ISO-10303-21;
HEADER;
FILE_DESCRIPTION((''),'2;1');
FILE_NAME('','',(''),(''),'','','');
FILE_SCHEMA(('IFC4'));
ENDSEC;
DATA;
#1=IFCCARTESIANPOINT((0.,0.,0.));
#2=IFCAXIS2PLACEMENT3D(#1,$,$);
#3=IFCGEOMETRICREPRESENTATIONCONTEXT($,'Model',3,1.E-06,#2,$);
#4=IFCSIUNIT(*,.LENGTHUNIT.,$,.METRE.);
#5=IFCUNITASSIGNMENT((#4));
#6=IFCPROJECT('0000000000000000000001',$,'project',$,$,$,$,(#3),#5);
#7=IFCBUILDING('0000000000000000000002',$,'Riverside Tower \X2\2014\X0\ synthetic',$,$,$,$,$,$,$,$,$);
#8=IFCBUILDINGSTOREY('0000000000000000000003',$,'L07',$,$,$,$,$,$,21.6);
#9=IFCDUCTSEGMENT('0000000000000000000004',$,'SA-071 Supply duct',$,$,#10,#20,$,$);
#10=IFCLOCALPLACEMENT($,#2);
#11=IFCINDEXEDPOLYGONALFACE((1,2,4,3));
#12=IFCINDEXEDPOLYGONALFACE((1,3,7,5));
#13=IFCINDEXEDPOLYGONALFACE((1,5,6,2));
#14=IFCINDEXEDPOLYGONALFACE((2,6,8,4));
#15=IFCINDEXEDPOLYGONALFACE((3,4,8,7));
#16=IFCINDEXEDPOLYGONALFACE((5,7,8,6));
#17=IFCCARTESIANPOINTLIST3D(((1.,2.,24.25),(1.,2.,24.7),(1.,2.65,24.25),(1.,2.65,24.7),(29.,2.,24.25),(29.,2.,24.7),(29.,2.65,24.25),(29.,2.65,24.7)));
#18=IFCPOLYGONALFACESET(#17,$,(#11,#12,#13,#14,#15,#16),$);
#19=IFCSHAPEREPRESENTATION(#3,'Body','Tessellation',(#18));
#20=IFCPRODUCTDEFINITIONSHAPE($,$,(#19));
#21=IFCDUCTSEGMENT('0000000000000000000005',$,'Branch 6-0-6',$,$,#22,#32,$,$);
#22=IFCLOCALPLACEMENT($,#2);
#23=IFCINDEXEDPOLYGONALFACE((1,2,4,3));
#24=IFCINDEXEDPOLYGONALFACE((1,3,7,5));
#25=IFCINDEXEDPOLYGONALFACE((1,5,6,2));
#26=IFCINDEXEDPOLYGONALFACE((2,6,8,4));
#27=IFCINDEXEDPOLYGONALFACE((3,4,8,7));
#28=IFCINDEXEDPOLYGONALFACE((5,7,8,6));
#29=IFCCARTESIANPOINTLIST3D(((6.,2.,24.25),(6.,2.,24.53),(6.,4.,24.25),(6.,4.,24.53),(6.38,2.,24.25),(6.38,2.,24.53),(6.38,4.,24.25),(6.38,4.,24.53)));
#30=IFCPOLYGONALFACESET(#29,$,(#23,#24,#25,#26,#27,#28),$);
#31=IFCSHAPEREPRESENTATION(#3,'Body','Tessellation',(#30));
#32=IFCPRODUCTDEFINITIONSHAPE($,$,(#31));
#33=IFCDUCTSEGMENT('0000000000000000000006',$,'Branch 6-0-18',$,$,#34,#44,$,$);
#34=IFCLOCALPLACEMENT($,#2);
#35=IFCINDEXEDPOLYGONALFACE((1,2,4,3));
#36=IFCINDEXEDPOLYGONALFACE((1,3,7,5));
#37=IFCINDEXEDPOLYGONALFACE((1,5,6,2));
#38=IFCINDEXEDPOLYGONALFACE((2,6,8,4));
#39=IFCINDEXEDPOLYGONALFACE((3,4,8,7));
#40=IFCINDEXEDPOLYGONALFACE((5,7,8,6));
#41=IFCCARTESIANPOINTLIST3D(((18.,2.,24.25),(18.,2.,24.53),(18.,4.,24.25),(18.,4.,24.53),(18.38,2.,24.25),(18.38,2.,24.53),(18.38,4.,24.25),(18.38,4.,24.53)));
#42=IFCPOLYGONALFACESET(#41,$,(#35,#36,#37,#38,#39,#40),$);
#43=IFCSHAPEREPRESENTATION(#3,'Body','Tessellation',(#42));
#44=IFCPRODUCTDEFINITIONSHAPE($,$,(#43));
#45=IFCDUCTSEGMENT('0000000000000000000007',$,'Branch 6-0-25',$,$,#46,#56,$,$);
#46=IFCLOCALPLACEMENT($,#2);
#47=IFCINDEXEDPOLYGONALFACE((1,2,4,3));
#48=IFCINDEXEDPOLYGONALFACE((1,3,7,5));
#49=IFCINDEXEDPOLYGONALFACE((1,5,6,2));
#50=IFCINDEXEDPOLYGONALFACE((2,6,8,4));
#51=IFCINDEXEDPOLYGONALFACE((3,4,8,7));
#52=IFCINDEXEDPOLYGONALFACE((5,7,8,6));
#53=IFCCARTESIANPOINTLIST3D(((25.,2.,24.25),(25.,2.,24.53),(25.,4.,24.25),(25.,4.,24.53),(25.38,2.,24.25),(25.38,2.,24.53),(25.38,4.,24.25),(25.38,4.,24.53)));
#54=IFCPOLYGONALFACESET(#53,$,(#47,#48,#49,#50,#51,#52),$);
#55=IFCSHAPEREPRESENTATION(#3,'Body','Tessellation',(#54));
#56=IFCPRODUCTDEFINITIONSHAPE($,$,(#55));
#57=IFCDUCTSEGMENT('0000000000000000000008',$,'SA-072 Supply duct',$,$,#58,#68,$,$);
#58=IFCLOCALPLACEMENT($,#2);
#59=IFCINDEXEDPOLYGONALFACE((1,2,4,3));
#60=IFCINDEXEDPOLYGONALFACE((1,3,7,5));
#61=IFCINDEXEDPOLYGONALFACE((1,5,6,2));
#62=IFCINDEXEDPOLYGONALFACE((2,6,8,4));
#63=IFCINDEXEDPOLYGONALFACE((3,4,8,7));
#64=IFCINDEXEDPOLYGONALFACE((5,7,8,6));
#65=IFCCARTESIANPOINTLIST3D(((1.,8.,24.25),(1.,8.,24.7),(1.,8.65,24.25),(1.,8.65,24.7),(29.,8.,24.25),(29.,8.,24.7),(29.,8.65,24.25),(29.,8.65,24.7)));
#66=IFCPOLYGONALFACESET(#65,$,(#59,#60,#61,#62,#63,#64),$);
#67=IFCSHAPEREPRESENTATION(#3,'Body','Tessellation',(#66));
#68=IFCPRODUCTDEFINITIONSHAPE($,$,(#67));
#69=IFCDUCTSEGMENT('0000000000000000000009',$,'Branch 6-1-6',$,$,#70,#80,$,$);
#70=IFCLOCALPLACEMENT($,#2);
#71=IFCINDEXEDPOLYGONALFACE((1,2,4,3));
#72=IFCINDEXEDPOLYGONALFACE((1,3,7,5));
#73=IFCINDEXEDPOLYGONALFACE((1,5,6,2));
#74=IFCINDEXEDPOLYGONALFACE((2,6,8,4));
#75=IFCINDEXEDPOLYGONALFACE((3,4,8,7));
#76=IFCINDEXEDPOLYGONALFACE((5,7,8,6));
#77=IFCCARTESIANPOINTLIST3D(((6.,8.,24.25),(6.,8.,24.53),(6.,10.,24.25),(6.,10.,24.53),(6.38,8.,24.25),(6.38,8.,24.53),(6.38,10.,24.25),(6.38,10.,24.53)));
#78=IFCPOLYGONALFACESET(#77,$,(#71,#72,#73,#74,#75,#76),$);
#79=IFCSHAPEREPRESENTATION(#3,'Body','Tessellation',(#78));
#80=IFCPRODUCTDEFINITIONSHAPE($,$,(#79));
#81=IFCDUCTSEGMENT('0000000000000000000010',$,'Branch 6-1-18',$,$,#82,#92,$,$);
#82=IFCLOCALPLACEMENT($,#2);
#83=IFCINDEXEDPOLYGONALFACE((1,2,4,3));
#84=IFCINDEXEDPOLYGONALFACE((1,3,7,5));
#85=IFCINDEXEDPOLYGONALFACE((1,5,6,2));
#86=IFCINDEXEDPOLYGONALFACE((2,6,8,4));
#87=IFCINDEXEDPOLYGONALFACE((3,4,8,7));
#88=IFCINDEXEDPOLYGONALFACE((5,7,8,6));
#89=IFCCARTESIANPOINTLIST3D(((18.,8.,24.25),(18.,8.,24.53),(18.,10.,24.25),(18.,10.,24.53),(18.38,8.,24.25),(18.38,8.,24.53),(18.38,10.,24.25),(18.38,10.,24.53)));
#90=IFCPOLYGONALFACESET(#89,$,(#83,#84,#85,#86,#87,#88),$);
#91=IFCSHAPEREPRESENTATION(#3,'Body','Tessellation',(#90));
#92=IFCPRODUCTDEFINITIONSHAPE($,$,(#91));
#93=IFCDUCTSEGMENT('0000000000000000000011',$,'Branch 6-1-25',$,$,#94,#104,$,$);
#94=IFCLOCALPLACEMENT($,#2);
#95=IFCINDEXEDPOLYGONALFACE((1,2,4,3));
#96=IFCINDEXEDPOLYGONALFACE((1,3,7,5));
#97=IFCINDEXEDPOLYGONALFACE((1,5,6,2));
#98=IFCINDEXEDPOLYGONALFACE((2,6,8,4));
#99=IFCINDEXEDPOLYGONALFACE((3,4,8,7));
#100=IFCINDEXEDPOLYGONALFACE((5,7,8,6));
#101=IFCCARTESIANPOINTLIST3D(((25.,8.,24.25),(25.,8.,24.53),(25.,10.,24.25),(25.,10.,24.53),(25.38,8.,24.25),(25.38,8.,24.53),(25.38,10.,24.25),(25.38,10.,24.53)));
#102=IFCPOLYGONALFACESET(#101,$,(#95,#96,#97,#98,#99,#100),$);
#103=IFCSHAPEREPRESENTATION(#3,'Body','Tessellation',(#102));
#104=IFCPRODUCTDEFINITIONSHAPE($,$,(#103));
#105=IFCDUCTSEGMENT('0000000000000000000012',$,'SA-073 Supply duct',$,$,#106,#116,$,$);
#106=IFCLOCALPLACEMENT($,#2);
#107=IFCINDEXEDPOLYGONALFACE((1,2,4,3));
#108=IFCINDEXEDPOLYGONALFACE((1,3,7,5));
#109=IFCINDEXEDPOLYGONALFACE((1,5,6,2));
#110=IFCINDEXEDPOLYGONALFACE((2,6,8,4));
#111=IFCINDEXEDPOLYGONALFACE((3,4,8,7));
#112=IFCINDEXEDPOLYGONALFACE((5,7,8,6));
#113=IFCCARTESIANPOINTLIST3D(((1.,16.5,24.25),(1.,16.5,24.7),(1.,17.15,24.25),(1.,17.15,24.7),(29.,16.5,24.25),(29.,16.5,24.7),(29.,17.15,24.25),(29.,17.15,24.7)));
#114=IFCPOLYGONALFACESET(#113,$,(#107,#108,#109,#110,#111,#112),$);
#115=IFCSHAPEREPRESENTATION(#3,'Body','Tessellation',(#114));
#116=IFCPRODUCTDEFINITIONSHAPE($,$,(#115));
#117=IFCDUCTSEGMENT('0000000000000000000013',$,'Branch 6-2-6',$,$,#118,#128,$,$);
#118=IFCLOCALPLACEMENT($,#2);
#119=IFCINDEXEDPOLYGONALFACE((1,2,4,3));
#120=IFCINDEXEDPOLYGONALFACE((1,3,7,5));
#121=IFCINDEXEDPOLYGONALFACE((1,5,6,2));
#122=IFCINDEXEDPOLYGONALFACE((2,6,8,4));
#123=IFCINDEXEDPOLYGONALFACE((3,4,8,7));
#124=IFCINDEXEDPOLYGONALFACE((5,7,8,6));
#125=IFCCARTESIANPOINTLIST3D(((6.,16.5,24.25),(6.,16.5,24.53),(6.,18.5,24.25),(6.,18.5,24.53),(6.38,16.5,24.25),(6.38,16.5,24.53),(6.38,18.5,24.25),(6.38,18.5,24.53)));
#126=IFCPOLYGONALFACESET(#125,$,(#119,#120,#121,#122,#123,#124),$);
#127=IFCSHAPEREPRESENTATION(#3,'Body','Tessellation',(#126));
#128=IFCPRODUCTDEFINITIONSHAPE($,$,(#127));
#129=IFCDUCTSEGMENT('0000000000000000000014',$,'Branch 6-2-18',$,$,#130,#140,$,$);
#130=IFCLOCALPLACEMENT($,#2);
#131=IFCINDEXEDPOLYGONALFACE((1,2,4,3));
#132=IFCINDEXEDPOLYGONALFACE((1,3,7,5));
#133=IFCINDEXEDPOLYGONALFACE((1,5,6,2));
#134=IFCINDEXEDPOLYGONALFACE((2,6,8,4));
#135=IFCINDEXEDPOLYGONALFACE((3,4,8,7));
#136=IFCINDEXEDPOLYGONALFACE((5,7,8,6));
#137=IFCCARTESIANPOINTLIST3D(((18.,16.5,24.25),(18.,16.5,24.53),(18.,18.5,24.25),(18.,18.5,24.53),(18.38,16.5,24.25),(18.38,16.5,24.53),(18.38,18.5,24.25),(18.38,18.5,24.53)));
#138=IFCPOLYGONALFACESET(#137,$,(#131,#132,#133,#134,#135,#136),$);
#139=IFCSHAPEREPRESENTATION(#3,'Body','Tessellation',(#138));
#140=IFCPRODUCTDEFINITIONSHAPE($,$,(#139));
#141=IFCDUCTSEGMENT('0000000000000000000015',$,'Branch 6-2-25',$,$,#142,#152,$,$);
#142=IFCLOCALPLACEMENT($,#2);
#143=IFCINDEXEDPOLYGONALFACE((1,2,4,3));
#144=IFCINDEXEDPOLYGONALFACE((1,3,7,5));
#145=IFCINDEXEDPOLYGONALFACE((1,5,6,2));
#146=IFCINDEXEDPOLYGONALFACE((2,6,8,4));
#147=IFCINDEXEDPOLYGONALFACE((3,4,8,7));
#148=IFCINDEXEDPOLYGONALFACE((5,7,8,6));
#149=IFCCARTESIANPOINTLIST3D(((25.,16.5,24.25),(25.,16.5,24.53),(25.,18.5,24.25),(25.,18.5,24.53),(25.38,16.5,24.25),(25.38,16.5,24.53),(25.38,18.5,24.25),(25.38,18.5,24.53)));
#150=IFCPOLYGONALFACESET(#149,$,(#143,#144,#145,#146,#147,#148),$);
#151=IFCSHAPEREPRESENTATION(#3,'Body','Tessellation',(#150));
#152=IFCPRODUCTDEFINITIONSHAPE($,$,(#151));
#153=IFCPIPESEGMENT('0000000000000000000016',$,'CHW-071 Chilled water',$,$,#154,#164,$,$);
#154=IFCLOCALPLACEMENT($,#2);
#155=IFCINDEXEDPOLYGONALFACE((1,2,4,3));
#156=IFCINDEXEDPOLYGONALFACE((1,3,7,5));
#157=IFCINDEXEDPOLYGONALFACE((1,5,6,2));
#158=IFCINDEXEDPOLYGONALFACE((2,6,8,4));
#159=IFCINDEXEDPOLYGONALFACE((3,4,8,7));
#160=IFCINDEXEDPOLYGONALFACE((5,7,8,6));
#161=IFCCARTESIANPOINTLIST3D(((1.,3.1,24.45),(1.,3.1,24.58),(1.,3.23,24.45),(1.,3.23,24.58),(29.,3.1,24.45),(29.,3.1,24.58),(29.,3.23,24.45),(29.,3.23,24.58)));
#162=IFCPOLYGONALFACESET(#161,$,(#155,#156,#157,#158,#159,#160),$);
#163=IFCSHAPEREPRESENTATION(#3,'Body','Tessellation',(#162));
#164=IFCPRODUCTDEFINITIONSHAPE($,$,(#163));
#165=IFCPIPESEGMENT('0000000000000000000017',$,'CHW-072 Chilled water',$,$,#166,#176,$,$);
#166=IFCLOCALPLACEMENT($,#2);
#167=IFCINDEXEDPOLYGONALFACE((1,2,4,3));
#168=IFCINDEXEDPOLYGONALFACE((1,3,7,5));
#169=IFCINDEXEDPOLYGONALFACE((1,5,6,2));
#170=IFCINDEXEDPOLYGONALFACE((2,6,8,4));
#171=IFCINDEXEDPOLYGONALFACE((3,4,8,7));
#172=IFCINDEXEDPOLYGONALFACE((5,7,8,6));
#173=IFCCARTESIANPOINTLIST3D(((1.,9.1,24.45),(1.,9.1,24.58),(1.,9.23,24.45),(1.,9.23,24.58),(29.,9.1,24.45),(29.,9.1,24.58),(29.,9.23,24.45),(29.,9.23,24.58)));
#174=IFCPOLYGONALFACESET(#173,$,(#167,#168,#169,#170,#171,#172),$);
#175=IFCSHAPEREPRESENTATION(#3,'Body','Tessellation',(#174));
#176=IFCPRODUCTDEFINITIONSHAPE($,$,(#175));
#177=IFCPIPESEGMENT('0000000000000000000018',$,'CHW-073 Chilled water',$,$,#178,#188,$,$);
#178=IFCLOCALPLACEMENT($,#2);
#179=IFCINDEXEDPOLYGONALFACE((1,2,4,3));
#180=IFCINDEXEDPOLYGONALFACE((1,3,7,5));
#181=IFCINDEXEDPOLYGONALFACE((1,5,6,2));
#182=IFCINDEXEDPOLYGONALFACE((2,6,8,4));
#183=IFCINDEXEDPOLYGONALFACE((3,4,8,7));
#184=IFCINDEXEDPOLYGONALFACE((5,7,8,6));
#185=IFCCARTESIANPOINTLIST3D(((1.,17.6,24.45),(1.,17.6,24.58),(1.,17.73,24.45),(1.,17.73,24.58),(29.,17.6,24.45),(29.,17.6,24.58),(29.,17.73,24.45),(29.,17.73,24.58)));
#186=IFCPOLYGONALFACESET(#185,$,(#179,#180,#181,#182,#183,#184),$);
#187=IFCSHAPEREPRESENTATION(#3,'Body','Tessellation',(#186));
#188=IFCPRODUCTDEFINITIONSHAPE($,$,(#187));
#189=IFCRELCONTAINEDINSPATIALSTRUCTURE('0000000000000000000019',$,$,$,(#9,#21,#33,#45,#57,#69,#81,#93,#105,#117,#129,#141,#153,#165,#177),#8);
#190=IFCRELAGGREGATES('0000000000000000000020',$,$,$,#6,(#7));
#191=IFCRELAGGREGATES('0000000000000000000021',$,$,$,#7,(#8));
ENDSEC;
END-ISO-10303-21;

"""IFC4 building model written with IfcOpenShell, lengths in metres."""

from ifc_helpers import new_model, si_unit, frame, origin, place, context, project, spatial, rectangle, extrude, element, save


model = new_model("IFC4")

# Units and contexts
model_context = context("Model", 3, precision=1e-06, world=origin())
ifc_project = project(units=[si_unit("LENGTHUNIT", "METRE")], contexts=[model_context])

# Building, storey
building = spatial("IfcBuilding", under=ifc_project, Name="Riverside Tower — synthetic")
storey = spatial("IfcBuildingStorey", under=building, Name="L07", Elevation=21.6)

# Duct segments
duct_segment_1_placement = place(None, frame((15.0, 2.325, 24.25)))
element("IfcDuctSegment", 1, at=duct_segment_1_placement, inside=storey, Name="SA-071 Supply duct", context=model_context, shape_type="SweptSolid", body=[
    extrude(rectangle(XDim=28.0, YDim=0.65), origin(), (0.0, 0.0, 1.0), 0.45),
])
for number, where, name in (
    (2, (6.19, 3.0, 24.25), "Branch 6-0-6"),
    (3, (18.19, 3.0, 24.25), "Branch 6-0-18"),
    (4, (25.19, 3.0, 24.25), "Branch 6-0-25"),
):
    element("IfcDuctSegment", number, at=place(None, frame(where)), inside=storey, Name=name, context=model_context, shape_type="SweptSolid", body=[
        extrude(rectangle(XDim=0.38, YDim=2.0), origin(), (0.0, 0.0, 1.0), 0.28),
    ])
duct_segment_2_placement = place(None, frame((15.0, 8.325, 24.25)))
element("IfcDuctSegment", 5, at=duct_segment_2_placement, inside=storey, Name="SA-072 Supply duct", context=model_context, shape_type="SweptSolid", body=[
    extrude(rectangle(XDim=28.0, YDim=0.65), origin(), (0.0, 0.0, 1.0), 0.45),
])
for number, where, name in (
    (6, (6.19, 9.0, 24.25), "Branch 6-1-6"),
    (7, (18.19, 9.0, 24.25), "Branch 6-1-18"),
    (8, (25.19, 9.0, 24.25), "Branch 6-1-25"),
):
    element("IfcDuctSegment", number, at=place(None, frame(where)), inside=storey, Name=name, context=model_context, shape_type="SweptSolid", body=[
        extrude(rectangle(XDim=0.38, YDim=2.0), origin(), (0.0, 0.0, 1.0), 0.28),
    ])
duct_segment_3_placement = place(None, frame((15.0, 16.825, 24.25)))
element("IfcDuctSegment", 9, at=duct_segment_3_placement, inside=storey, Name="SA-073 Supply duct", context=model_context, shape_type="SweptSolid", body=[
    extrude(rectangle(XDim=28.0, YDim=0.65), origin(), (0.0, 0.0, 1.0), 0.45),
])
for number, where, name in (
    (10, (6.19, 17.5, 24.25), "Branch 6-2-6"),
    (11, (18.19, 17.5, 24.25), "Branch 6-2-18"),
    (12, (25.19, 17.5, 24.25), "Branch 6-2-25"),
):
    element("IfcDuctSegment", number, at=place(None, frame(where)), inside=storey, Name=name, context=model_context, shape_type="SweptSolid", body=[
        extrude(rectangle(XDim=0.38, YDim=2.0), origin(), (0.0, 0.0, 1.0), 0.28),
    ])

# Pipe segments
for number, where, name in (
    (13, (15.0, 3.165, 24.45), "CHW-071 Chilled water"),
    (14, (15.0, 9.165, 24.45), "CHW-072 Chilled water"),
    (15, (15.0, 17.665, 24.45), "CHW-073 Chilled water"),
):
    element("IfcPipeSegment", number, at=place(None, frame(where)), inside=storey, Name=name, context=model_context, shape_type="SweptSolid", body=[
        extrude(rectangle(XDim=28.0, YDim=0.13), origin(), (0.0, 0.0, 1.0), 0.13),
    ])

save(model, "model.ifc")
